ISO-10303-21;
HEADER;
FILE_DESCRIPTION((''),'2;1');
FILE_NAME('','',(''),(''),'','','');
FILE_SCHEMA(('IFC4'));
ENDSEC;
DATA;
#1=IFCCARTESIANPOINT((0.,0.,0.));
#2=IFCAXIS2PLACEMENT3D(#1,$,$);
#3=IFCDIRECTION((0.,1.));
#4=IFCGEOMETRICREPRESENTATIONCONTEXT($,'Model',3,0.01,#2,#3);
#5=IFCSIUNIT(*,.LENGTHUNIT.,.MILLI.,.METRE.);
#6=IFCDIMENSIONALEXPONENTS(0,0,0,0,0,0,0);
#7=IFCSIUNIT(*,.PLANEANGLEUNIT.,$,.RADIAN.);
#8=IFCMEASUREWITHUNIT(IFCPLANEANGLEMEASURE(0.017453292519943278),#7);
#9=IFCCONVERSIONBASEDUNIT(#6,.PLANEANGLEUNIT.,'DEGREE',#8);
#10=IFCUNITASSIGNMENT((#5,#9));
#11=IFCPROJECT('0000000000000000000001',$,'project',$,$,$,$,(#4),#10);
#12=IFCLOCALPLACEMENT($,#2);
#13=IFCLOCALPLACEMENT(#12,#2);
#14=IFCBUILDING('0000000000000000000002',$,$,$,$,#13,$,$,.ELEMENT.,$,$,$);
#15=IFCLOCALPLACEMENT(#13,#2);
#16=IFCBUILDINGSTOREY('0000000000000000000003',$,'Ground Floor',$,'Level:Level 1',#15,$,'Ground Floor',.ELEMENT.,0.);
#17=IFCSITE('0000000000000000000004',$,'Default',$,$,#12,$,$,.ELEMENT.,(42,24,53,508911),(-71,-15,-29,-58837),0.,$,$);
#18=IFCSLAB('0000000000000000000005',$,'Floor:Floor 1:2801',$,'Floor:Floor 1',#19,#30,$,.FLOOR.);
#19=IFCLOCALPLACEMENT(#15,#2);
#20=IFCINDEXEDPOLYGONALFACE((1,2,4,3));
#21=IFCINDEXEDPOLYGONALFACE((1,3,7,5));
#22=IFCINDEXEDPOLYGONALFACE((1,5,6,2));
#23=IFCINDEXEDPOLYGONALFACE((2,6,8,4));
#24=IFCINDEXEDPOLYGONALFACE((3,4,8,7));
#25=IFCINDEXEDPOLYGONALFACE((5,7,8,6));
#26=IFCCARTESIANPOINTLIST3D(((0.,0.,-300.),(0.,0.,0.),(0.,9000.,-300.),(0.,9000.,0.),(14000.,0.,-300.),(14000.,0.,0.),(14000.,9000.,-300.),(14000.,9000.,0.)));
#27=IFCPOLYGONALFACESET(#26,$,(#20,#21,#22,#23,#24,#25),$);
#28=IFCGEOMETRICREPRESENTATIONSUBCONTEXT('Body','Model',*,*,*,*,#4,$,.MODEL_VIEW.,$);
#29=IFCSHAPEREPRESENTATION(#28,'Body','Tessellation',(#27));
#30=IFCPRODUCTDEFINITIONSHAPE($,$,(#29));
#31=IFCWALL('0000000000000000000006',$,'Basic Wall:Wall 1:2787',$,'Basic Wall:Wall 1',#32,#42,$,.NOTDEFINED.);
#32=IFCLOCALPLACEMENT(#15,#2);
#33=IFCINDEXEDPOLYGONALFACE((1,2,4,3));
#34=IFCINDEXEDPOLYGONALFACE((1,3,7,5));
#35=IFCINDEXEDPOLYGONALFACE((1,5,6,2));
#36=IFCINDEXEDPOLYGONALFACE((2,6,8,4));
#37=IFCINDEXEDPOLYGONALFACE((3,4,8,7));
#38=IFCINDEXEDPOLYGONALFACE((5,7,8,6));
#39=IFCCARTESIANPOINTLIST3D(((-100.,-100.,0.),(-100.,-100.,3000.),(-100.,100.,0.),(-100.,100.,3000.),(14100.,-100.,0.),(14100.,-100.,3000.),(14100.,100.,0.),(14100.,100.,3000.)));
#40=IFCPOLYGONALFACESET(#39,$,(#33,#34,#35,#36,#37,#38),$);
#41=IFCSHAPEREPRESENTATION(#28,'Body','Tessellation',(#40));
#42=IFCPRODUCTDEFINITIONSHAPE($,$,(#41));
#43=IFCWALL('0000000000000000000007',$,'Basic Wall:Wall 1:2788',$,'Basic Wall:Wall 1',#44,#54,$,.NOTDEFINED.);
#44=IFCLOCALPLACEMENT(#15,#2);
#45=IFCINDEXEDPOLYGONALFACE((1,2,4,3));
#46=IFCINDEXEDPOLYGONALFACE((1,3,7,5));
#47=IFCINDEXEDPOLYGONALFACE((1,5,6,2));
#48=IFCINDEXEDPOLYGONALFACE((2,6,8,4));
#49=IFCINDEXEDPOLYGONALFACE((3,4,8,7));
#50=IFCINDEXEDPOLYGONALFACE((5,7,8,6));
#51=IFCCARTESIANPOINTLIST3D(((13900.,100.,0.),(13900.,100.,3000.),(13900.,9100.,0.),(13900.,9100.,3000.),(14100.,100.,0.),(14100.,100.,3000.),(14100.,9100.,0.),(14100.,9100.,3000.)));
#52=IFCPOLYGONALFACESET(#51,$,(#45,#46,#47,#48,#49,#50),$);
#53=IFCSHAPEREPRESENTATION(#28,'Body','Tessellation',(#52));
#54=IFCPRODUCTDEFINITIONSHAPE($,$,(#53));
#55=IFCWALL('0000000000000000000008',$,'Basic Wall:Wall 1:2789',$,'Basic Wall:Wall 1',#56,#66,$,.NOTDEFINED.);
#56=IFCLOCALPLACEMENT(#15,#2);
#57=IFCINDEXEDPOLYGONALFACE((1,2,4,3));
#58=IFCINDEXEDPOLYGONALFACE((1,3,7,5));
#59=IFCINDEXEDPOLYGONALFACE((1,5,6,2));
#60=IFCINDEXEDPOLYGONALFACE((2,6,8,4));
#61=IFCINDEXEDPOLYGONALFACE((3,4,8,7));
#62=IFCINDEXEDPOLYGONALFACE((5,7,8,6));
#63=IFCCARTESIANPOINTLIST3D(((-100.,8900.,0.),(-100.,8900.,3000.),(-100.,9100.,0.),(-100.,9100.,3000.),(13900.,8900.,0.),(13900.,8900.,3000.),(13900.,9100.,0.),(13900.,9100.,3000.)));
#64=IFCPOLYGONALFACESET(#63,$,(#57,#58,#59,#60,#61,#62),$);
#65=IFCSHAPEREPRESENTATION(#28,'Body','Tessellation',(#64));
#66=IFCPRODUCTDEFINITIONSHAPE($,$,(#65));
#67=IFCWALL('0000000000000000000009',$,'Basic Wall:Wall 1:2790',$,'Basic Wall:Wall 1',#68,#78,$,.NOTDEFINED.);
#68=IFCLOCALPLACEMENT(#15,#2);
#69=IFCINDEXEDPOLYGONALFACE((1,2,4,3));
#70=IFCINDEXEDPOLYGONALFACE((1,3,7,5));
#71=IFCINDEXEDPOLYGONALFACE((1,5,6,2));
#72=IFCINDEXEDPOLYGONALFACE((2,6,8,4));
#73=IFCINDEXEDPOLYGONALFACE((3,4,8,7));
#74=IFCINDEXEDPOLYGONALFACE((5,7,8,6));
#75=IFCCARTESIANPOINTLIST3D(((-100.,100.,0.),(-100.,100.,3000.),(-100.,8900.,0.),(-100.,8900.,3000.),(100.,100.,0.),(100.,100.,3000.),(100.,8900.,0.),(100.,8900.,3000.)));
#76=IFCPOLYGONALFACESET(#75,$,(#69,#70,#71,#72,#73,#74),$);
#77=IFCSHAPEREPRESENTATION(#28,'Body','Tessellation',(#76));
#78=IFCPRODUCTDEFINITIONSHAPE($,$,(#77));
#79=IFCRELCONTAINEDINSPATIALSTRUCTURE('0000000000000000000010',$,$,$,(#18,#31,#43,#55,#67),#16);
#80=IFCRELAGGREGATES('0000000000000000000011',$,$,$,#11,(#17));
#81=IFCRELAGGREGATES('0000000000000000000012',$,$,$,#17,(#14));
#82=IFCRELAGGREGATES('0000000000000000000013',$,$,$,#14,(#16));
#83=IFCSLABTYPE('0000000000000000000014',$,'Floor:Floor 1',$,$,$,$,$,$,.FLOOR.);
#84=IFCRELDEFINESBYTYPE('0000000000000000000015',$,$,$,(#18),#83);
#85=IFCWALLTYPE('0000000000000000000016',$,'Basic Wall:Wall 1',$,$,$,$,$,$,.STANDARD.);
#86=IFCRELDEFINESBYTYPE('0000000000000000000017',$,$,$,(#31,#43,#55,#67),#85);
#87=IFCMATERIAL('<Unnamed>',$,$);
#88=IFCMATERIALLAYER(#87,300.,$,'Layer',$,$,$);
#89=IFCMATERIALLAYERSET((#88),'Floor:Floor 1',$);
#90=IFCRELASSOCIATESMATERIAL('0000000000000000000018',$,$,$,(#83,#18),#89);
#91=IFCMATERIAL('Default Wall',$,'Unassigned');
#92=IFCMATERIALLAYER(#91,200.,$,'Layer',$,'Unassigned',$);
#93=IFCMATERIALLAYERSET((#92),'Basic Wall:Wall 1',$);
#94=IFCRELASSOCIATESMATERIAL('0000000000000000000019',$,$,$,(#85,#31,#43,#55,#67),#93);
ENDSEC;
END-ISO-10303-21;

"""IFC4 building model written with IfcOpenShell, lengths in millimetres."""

from ifc_helpers import new_model, entity, si_unit, converted_unit, direction, frame, frame_2d, origin, origin_2d_with_axis, place, context, subcontext, project, spatial, rectangle, extrude, material, layer, layer_set, layer_usage, type_object, element, save


model = new_model("IFC4")

# Units and contexts
model_context = context("Model", 3, precision=0.01, world=origin(), true_north=direction((0.0, 1.0)))
body_context = subcontext(model_context, "Body", "Model", "MODEL_VIEW")
ifc_project = project(units=[si_unit("LENGTHUNIT", "METRE", prefix="MILLI"), converted_unit("PLANEANGLEUNIT", "DEGREE", entity("IfcPlaneAngleMeasure", 0.017453292519943278), si_unit("PLANEANGLEUNIT", "RADIAN"), dimensions=[0, 0, 0, 0, 0, 0, 0])], contexts=[model_context])

# Site, building, storey
site_placement = place(None, origin())
site = spatial("IfcSite", under=ifc_project, at=site_placement, Name="Default", CompositionType="ELEMENT", RefLatitude=(42, 24, 53, 508911), RefLongitude=(-71, -15, -29, -58837), RefElevation=0.0)
building_placement = place(site_placement, origin())
building = spatial("IfcBuilding", under=site, at=building_placement, CompositionType="ELEMENT")
storey_placement = place(building_placement, origin())
storey = spatial("IfcBuildingStorey", under=building, at=storey_placement, Name="Ground Floor", ObjectType="Level:Level 1", LongName="Ground Floor", CompositionType="ELEMENT", Elevation=0.0)

# Shared definitions
ifc_material_1 = material(Name="Default Wall", Category="Unassigned")

# Slab
ifc_material_2 = material(Name="<Unnamed>")
ifc_layer_1 = layer(ifc_material_2, 300.0, Name="Layer")
ifc_layer_set_1 = layer_set([ifc_layer_1], Name="Floor:Floor 1")
ifc_layer_usage_1 = layer_usage(ifc_layer_set_1, "AXIS3", "POSITIVE", 0.0)
slab_type = type_object("IfcSlabType", Name="Floor:Floor 1", PredefinedType="FLOOR", material=ifc_layer_set_1)
slab_placement = place(storey_placement, origin())
element("IfcSlab", 1, at=slab_placement, inside=storey, type_object=slab_type, material=ifc_layer_usage_1, Name="Floor:Floor 1:2801", ObjectType="Floor:Floor 1", PredefinedType="FLOOR", context=body_context, shape_type="SweptSolid", body=[
    extrude(rectangle(XDim=9000.0, YDim=14000.0, at=origin_2d_with_axis()), frame((7000.0, 4500.0, 0.0), z_axis=(0.0, 0.0, -1.0), x_axis=(0.0, 1.0, 0.0)), (0.0, 0.0, 1.0), 300.0),
])

# Walls
ifc_layer_2 = layer(ifc_material_1, 200.0, Name="Layer", Category="Unassigned")
ifc_layer_set_2 = layer_set([ifc_layer_2], Name="Basic Wall:Wall 1")
ifc_layer_usage_2 = layer_usage(ifc_layer_set_2, "AXIS2", "NEGATIVE", 100.0)
wall_type = type_object("IfcWallType", Name="Basic Wall:Wall 1", PredefinedType="STANDARD", material=ifc_layer_set_2)
wall_1_placement = place(storey_placement, frame((-100.0, 0.0, 0.0)))
element("IfcWall", 2, at=wall_1_placement, inside=storey, type_object=wall_type, material=ifc_layer_usage_2, Name="Basic Wall:Wall 1:2787", ObjectType="Basic Wall:Wall 1", PredefinedType="NOTDEFINED", context=body_context, shape_type="SweptSolid", body=[
    extrude(rectangle(XDim=14200.0, YDim=200.0, at=frame_2d((7100.0, 0.0), x_axis=(-1.0, 0.0))), origin(), (0.0, 0.0, 1.0), 3000.0),
])
ifc_layer_usage_3 = layer_usage(ifc_layer_set_2, "AXIS2", "NEGATIVE", 100.0)
wall_2_placement = place(storey_placement, frame((14000.0, 100.0, 0.0), z_axis=(0.0, 0.0, 1.0), x_axis=(0.0, 1.0, 0.0)))
element("IfcWall", 3, at=wall_2_placement, inside=storey, type_object=wall_type, material=ifc_layer_usage_3, Name="Basic Wall:Wall 1:2788", ObjectType="Basic Wall:Wall 1", PredefinedType="NOTDEFINED", context=body_context, shape_type="SweptSolid", body=[
    extrude(rectangle(XDim=9000.0, YDim=200.0, at=frame_2d((4500.0, 0.0), x_axis=(-1.0, 0.0))), origin(), (0.0, 0.0, 1.0), 3000.0),
])
ifc_layer_usage_4 = layer_usage(ifc_layer_set_2, "AXIS2", "NEGATIVE", 100.0)
wall_3_placement = place(storey_placement, frame((13900.0, 9000.0, 0.0), z_axis=(0.0, 0.0, 1.0), x_axis=(-1.0, 0.0, 0.0)))
element("IfcWall", 4, at=wall_3_placement, inside=storey, type_object=wall_type, material=ifc_layer_usage_4, Name="Basic Wall:Wall 1:2789", ObjectType="Basic Wall:Wall 1", PredefinedType="NOTDEFINED", context=body_context, shape_type="SweptSolid", body=[
    extrude(rectangle(XDim=14000.0, YDim=200.0, at=frame_2d((7000.0, 0.0), x_axis=(-1.0, 0.0))), origin(), (0.0, 0.0, 1.0), 3000.0),
])
ifc_layer_usage_5 = layer_usage(ifc_layer_set_2, "AXIS2", "NEGATIVE", 100.0)
wall_4_placement = place(storey_placement, frame((0.0, 8900.0, 0.0), z_axis=(0.0, 0.0, 1.0), x_axis=(0.0, -1.0, 0.0)))
element("IfcWall", 5, at=wall_4_placement, inside=storey, type_object=wall_type, material=ifc_layer_usage_5, Name="Basic Wall:Wall 1:2790", ObjectType="Basic Wall:Wall 1", PredefinedType="NOTDEFINED", context=body_context, shape_type="SweptSolid", body=[
    extrude(rectangle(XDim=8800.0, YDim=200.0, at=frame_2d((4400.0, 0.0), x_axis=(-1.0, 0.0))), origin(), (0.0, 0.0, 1.0), 3000.0),
])

save(model, "model.ifc")
